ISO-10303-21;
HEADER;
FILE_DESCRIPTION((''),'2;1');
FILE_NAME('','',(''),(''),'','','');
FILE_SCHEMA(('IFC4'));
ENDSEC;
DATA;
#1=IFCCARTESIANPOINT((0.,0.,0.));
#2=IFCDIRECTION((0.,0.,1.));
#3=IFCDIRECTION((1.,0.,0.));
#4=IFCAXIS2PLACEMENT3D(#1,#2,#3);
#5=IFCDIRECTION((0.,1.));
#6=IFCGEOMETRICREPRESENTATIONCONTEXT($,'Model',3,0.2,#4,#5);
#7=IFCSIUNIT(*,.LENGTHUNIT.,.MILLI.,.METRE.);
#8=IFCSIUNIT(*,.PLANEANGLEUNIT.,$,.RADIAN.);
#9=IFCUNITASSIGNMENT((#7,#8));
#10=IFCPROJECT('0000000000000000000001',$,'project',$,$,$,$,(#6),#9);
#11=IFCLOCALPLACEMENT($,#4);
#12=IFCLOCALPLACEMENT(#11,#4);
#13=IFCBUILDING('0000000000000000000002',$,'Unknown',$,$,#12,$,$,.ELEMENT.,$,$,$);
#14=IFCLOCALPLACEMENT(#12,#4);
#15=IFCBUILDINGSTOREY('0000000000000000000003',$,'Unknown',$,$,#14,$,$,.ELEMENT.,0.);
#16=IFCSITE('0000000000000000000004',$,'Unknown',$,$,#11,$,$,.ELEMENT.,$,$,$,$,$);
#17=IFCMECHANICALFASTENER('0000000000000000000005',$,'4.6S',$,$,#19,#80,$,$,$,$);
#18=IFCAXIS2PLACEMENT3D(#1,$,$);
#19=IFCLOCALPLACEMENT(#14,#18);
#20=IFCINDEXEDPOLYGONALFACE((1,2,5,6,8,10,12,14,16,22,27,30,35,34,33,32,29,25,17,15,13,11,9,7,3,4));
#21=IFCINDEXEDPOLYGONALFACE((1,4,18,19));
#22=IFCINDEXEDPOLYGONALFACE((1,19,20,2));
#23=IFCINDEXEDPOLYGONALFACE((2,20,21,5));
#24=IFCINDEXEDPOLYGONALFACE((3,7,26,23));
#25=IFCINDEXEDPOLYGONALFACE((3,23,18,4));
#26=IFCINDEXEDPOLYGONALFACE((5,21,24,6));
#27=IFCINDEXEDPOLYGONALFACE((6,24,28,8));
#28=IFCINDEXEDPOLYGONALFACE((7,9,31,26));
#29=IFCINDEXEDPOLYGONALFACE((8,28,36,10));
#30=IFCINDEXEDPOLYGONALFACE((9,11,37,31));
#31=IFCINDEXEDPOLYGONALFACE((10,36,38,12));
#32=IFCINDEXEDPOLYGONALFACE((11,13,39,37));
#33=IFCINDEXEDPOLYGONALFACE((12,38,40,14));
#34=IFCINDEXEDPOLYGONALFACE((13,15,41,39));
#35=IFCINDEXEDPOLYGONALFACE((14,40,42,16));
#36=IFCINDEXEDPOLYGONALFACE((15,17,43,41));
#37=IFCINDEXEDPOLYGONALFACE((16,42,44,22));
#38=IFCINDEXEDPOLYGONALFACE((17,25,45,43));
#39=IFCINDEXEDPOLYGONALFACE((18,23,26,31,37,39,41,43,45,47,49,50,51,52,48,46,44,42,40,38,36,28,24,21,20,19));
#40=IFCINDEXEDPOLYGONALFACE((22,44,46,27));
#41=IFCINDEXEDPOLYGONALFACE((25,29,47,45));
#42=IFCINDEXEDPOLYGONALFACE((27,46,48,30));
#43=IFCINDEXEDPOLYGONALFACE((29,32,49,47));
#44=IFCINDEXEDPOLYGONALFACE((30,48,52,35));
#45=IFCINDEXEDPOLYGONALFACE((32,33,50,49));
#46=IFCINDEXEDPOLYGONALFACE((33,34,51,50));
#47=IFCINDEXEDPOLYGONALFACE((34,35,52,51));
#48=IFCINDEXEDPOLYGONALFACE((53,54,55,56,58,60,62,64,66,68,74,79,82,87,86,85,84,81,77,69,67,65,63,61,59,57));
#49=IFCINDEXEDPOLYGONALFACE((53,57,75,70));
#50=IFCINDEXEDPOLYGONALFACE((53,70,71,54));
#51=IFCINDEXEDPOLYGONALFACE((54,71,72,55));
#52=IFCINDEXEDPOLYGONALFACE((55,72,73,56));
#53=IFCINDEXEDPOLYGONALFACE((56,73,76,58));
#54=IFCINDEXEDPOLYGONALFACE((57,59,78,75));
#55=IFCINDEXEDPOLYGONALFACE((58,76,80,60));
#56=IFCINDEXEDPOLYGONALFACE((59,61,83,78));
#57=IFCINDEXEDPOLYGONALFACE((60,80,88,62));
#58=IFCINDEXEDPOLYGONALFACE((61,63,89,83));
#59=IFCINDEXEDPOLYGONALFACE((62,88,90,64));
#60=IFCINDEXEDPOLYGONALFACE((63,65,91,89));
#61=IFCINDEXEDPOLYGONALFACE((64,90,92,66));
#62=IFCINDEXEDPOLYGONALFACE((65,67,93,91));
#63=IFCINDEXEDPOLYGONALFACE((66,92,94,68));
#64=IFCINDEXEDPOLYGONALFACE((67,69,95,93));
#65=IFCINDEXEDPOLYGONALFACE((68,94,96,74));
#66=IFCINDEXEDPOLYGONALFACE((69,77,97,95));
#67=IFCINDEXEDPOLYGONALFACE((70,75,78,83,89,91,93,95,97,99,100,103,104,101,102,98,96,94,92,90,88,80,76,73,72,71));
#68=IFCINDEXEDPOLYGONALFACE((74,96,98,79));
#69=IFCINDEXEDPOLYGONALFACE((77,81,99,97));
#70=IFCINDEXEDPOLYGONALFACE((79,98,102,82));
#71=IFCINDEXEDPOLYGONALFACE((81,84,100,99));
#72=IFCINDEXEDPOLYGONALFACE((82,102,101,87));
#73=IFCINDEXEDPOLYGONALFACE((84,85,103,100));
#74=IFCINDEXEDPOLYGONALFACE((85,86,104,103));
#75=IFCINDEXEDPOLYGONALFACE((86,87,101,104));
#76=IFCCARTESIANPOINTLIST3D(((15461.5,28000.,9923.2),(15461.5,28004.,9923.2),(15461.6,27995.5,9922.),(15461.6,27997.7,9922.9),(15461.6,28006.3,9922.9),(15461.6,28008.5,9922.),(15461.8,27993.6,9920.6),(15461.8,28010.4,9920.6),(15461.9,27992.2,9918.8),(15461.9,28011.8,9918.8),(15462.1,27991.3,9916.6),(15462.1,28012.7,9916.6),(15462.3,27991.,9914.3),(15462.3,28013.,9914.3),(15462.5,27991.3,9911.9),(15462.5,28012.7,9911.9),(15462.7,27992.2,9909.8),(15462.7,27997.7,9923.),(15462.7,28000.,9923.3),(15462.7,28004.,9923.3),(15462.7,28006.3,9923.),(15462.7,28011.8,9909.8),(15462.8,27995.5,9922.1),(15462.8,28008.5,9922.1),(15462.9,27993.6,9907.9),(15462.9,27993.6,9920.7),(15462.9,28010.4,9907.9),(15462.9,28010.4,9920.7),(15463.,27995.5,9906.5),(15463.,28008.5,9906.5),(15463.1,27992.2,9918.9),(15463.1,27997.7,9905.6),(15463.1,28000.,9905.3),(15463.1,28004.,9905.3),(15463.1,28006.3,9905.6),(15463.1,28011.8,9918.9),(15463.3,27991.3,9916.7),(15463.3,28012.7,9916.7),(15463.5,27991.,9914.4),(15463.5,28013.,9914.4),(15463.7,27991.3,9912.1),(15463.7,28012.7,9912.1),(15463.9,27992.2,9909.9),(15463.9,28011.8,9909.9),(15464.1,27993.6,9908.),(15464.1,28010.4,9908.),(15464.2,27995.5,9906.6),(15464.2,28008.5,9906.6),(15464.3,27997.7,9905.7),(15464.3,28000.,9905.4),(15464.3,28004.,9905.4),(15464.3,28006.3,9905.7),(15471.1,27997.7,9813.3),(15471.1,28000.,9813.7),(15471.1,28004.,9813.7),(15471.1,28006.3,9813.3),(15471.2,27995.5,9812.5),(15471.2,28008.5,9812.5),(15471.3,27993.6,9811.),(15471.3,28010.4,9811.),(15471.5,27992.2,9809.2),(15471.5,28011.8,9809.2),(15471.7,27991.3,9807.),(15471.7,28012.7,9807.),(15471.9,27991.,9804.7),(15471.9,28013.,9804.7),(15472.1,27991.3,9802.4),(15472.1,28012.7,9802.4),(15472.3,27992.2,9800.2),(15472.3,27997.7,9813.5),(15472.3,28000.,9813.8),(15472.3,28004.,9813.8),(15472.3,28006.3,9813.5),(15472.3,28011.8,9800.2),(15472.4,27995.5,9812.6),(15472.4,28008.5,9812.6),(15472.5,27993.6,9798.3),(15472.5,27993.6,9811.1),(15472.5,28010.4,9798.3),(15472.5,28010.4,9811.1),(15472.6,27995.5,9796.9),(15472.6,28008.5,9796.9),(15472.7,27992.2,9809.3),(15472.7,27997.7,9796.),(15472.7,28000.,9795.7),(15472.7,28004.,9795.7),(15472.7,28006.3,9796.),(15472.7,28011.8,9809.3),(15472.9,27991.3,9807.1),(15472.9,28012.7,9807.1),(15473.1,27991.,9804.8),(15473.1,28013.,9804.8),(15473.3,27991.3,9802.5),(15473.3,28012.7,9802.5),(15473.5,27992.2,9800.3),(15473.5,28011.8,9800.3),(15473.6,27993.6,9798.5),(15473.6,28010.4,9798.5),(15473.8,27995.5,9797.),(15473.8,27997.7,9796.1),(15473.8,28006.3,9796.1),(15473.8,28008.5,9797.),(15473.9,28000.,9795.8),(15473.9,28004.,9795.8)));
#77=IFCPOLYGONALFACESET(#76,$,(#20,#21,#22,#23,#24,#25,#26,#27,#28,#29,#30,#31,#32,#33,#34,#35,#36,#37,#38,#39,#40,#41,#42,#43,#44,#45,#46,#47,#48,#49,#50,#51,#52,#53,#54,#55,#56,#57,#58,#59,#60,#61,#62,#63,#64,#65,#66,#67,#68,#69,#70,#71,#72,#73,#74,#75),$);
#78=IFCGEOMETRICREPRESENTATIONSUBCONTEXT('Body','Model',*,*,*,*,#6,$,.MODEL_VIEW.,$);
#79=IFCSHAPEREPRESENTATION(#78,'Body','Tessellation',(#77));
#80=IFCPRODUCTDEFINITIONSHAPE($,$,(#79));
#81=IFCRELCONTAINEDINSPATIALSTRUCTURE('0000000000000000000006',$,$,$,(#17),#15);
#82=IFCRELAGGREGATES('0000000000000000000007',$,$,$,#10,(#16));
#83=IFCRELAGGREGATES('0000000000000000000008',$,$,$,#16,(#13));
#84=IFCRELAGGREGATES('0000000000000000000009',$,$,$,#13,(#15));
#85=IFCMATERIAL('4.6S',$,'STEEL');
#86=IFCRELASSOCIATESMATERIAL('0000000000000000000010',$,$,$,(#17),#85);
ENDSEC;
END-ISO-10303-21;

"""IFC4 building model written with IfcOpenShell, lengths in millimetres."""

from ifc_helpers import new_model, si_unit, direction, frame, origin_with_axes, place, context, subcontext, project, spatial, line, arc, indexed_curve, outline, extrude, source, transform, mapped, material, element, save


model = new_model("IFC4")

# Units and contexts
model_context = context("Model", 3, precision=0.2, world=origin_with_axes(), true_north=direction((0.0, 1.0)))
body_context = subcontext(model_context, "Body", "Model", "MODEL_VIEW")
ifc_project = project(units=[si_unit("LENGTHUNIT", "METRE", prefix="MILLI"), si_unit("PLANEANGLEUNIT", "RADIAN")], contexts=[model_context])

# Site, building, storey
site_placement = place(None, origin_with_axes())
site = spatial("IfcSite", under=ifc_project, at=site_placement, Name="Unknown", CompositionType="ELEMENT")
building_placement = place(site_placement, origin_with_axes())
building = spatial("IfcBuilding", under=site, at=building_placement, Name="Unknown", CompositionType="ELEMENT")
storey_placement = place(building_placement, origin_with_axes())
storey = spatial("IfcBuildingStorey", under=building, at=storey_placement, Name="Unknown", CompositionType="ELEMENT", Elevation=0.0)

# Mechanical fastener
ifc_material_1 = material(Name="4.6S", Category="STEEL")
shared_shape_1 = source(origin_with_axes(), body_context, "Body", "SweptSolid", [
    extrude(outline(indexed_curve([(-2.0, 9.0), (2.0, 9.0), (2.0, 9.0), (8.4, 6.4), (11.0, 0.0), (8.4, -6.4), (2.0, -9.0), (-2.0, -9.0), (-2.8, -9.0), (-11.0, 0.0), (-8.4, 6.4)], segments=[line(1, 2, 3), arc(3, 4, 5), arc(5, 6, 7), line(7, 8), arc(8, 9, 10), arc(10, 11, 1)])), frame((0.0, 0.0, 0.6), z_axis=(0.0, 0.0, -1.0), x_axis=(0.0, 1.0, 0.0)), (0.0, 0.0, 1.0), 1.2),
])
mechanical_fastener_1_placement = place(storey_placement, frame((15472.5, 28002.0, 9804.7), z_axis=(-0.996195, 0.0, -0.087152), x_axis=(-0.087152, 0.0, 0.996195)))
element("IfcMechanicalFastener", 1, at=mechanical_fastener_1_placement, inside=storey, material=ifc_material_1, Name="4.6S", context=body_context, shape_type="MappedRepresentation", body=[
    mapped(shared_shape_1, transform((0.0, 0.0, 0.0))),
    mapped(shared_shape_1, transform((110.0, 0.0, 0.0))),
])

save(model, "model.ifc")
